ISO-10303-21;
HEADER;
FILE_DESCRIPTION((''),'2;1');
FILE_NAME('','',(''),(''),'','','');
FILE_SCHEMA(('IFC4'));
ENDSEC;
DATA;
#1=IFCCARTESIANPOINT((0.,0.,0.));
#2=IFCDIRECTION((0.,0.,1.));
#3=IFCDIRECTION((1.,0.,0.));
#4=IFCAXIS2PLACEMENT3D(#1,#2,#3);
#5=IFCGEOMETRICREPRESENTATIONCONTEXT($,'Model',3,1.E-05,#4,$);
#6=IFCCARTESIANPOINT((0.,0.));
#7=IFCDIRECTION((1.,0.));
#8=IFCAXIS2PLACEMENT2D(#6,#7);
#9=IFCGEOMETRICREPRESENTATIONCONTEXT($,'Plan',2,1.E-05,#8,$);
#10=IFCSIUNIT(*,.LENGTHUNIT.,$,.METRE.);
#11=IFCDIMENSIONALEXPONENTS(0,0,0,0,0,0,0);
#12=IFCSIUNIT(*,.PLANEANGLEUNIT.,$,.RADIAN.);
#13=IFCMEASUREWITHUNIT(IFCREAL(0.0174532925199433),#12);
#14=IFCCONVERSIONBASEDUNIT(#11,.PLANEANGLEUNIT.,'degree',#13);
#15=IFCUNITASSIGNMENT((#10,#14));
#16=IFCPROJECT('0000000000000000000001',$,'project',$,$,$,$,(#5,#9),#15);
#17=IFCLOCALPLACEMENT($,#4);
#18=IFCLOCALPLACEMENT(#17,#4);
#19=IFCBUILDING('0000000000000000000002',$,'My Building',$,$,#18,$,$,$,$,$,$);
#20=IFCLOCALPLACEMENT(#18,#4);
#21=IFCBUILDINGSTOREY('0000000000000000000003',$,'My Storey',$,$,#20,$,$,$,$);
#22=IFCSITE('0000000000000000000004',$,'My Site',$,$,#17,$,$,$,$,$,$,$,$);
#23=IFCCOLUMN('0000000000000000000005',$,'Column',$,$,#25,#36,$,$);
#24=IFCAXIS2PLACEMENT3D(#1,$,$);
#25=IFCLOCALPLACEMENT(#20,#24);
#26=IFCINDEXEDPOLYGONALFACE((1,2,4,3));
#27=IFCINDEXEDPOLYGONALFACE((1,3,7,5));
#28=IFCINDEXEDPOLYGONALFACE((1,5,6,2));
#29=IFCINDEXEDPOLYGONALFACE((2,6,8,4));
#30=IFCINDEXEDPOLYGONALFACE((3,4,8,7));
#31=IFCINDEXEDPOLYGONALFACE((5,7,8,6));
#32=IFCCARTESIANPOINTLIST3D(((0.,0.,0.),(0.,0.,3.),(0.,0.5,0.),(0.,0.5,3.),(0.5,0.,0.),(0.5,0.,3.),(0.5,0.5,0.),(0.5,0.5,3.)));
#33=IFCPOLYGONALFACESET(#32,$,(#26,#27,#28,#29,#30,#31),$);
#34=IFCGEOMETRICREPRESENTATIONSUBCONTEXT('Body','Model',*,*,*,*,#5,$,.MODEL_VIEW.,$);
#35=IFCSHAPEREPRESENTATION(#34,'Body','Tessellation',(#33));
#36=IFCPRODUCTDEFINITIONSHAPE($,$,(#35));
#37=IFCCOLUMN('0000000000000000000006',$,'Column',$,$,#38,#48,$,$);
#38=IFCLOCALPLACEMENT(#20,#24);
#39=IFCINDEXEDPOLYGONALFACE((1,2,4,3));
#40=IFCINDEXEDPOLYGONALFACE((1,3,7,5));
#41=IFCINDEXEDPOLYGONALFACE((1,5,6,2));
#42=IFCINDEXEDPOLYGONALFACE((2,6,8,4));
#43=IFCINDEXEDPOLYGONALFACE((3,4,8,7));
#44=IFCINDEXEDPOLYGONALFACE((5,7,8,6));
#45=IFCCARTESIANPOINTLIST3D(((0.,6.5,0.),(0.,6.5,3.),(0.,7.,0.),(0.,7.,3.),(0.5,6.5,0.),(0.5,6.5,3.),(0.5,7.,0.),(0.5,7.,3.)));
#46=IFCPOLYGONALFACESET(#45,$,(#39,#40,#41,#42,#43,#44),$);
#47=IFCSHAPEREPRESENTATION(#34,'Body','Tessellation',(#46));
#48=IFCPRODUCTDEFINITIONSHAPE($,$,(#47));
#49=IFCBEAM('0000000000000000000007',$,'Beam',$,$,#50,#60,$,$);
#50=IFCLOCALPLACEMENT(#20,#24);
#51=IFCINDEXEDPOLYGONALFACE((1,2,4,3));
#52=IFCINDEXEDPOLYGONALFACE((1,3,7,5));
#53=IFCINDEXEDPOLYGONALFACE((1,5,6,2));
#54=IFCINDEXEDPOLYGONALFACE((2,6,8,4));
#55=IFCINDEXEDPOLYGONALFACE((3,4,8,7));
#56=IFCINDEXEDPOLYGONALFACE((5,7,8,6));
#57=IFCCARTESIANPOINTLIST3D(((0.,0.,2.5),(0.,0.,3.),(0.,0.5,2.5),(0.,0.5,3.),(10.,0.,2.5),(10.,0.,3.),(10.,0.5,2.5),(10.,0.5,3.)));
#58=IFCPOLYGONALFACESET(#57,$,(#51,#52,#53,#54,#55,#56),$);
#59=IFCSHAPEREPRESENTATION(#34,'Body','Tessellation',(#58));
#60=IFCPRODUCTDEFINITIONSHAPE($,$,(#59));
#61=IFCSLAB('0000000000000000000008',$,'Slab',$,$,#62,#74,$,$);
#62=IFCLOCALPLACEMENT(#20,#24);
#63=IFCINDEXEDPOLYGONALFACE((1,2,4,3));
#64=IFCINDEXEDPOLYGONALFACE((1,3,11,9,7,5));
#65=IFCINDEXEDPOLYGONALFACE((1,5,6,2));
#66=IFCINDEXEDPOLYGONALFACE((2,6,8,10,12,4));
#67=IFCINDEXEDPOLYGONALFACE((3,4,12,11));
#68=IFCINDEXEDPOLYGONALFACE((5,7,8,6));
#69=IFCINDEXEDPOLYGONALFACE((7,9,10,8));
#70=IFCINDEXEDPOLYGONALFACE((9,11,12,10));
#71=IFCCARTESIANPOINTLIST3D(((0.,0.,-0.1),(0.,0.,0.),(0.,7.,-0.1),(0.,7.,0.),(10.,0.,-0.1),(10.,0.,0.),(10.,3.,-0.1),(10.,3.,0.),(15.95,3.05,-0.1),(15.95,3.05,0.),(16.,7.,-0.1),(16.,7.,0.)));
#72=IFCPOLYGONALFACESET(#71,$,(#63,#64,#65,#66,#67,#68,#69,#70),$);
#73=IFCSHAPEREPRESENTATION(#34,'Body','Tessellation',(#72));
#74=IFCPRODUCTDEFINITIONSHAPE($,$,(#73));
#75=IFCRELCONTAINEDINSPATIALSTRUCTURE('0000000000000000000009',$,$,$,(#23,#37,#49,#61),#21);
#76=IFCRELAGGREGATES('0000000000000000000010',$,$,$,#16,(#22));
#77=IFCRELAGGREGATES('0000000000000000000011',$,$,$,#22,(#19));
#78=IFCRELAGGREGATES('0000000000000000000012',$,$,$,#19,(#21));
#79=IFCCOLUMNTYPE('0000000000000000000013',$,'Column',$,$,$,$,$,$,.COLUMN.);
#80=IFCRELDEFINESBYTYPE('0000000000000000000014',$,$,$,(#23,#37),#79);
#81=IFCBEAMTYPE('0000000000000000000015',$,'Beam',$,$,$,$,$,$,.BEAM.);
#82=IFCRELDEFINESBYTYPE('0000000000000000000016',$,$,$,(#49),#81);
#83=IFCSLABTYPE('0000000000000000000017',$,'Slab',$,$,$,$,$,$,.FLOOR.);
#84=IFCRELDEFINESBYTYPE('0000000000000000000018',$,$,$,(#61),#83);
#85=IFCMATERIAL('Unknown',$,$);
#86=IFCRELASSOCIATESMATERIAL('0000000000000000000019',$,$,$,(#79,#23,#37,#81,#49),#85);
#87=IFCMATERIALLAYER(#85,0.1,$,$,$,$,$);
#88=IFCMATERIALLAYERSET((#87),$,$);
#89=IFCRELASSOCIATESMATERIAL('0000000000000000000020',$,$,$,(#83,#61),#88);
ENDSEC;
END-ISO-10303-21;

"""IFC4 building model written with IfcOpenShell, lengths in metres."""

from ifc_helpers import new_model, entity, si_unit, converted_unit, frame, origin_with_axes, origin_2d_with_axis, place, context, subcontext, project, spatial, indexed_curve, rectangle, outline, extrude, material, layer, layer_set, layer_usage, material_profile, profile_set, profile_usage, type_object, element, save


model = new_model("IFC4")

# Units and contexts
model_context = context("Model", 3, precision=1e-05, world=origin_with_axes())
plan_context = context("Plan", 2, precision=1e-05, world=origin_2d_with_axis())
body_context_1 = subcontext(model_context, "Body", "Model", "MODEL_VIEW")
ifc_project = project(units=[si_unit("LENGTHUNIT", "METRE"), converted_unit("PLANEANGLEUNIT", "degree", entity("IfcReal", 0.0174532925199433), si_unit("PLANEANGLEUNIT", "RADIAN"), dimensions=[0, 0, 0, 0, 0, 0, 0])], contexts=[model_context, plan_context])

# Site, building, storey
site_placement = place(None, origin_with_axes())
site = spatial("IfcSite", under=ifc_project, at=site_placement, Name="My Site")
building_placement = place(site_placement, origin_with_axes())
building = spatial("IfcBuilding", under=site, at=building_placement, Name="My Building")
storey_placement = place(building_placement, origin_with_axes())
storey = spatial("IfcBuildingStorey", under=building, at=storey_placement, Name="My Storey")

# Columns
ifc_material = material(Name="Unknown")
ifc_material_profile_1 = material_profile(ifc_material, rectangle(XDim=0.5, YDim=0.5))
ifc_profile_set_1 = profile_set([ifc_material_profile_1])
ifc_profile_usage_1 = profile_usage(ifc_profile_set_1, cardinal=5)
column_type = type_object("IfcColumnType", Name="Column", PredefinedType="COLUMN", material=ifc_profile_set_1)
column_1_placement = place(storey_placement, frame((0.25, 0.25, 0.0), z_axis=(0.0, 0.0, 1.0), x_axis=(1.0, 0.0, 0.0)))
element("IfcColumn", 1, at=column_1_placement, inside=storey, type_object=column_type, material=ifc_profile_usage_1, Name="Column", context=body_context_1, shape_type="SweptSolid", body=[
    extrude(rectangle(XDim=0.5, YDim=0.5), origin_with_axes(), (0.0, 0.0, 1.0), 3.0),
])
ifc_profile_usage_2 = profile_usage(ifc_profile_set_1, cardinal=5)
column_2_placement = place(storey_placement, frame((0.25, 6.75, 0.0), z_axis=(0.0, 0.0, 1.0), x_axis=(1.0, 0.0, 0.0)))
element("IfcColumn", 2, at=column_2_placement, inside=storey, type_object=column_type, material=ifc_profile_usage_2, Name="Column", context=body_context_1, shape_type="SweptSolid", body=[
    extrude(rectangle(XDim=0.5, YDim=0.5), origin_with_axes(), (0.0, 0.0, 1.0), 3.0),
])

# Beam
ifc_material_profile_2 = material_profile(ifc_material, rectangle(XDim=0.5, YDim=0.5))
ifc_profile_set_2 = profile_set([ifc_material_profile_2])
ifc_profile_usage_3 = profile_usage(ifc_profile_set_2, cardinal=8)
beam_type = type_object("IfcBeamType", Name="Beam", PredefinedType="BEAM", material=ifc_profile_set_2)
beam_placement = place(storey_placement, frame((0.0, 0.25, 3.0), z_axis=(1.0, 0.0, 0.0), x_axis=(0.0, 1.0, 0.0)))
element("IfcBeam", 3, at=beam_placement, inside=storey, type_object=beam_type, material=ifc_profile_usage_3, Name="Beam", context=body_context_1, shape_type="SweptSolid", body=[
    extrude(rectangle(XDim=0.5, YDim=0.5), frame((0.0, -0.25, 0.0), z_axis=(0.0, 0.0, 1.0), x_axis=(1.0, 0.0, 0.0)), (0.0, 0.0, 1.0), 10.0),
])

# Slab
ifc_layer_1 = layer(ifc_material, 0.1)
ifc_layer_set_1 = layer_set([ifc_layer_1])
ifc_layer_usage_1 = layer_usage(ifc_layer_set_1, "AXIS3", "POSITIVE", -0.1)
slab_type = type_object("IfcSlabType", Name="Slab", PredefinedType="FLOOR", material=ifc_layer_set_1)
slab_placement = place(storey_placement, frame((0.0, 7.0, 0.0), z_axis=(0.0, 0.0, 1.0), x_axis=(1.0, 0.0, 0.0)))
element("IfcSlab", 4, at=slab_placement, inside=storey, type_object=slab_type, material=ifc_layer_usage_1, Name="Slab", context=body_context_1, shape_type="SweptSolid", body=[
    extrude(outline(indexed_curve([(0.0, 0.0), (0.0, -7.0), (10.0, -7.0), (10.0, -4.0), (15.95, -3.95), (16.0, 0.0), (0.0, 0.0)])), frame((0.0, 0.0, -0.1), z_axis=(0.0, 0.0, 1.0), x_axis=(1.0, 0.0, 0.0)), (0.0, 0.0, 1.0), 0.1),
])

save(model, "model.ifc")
